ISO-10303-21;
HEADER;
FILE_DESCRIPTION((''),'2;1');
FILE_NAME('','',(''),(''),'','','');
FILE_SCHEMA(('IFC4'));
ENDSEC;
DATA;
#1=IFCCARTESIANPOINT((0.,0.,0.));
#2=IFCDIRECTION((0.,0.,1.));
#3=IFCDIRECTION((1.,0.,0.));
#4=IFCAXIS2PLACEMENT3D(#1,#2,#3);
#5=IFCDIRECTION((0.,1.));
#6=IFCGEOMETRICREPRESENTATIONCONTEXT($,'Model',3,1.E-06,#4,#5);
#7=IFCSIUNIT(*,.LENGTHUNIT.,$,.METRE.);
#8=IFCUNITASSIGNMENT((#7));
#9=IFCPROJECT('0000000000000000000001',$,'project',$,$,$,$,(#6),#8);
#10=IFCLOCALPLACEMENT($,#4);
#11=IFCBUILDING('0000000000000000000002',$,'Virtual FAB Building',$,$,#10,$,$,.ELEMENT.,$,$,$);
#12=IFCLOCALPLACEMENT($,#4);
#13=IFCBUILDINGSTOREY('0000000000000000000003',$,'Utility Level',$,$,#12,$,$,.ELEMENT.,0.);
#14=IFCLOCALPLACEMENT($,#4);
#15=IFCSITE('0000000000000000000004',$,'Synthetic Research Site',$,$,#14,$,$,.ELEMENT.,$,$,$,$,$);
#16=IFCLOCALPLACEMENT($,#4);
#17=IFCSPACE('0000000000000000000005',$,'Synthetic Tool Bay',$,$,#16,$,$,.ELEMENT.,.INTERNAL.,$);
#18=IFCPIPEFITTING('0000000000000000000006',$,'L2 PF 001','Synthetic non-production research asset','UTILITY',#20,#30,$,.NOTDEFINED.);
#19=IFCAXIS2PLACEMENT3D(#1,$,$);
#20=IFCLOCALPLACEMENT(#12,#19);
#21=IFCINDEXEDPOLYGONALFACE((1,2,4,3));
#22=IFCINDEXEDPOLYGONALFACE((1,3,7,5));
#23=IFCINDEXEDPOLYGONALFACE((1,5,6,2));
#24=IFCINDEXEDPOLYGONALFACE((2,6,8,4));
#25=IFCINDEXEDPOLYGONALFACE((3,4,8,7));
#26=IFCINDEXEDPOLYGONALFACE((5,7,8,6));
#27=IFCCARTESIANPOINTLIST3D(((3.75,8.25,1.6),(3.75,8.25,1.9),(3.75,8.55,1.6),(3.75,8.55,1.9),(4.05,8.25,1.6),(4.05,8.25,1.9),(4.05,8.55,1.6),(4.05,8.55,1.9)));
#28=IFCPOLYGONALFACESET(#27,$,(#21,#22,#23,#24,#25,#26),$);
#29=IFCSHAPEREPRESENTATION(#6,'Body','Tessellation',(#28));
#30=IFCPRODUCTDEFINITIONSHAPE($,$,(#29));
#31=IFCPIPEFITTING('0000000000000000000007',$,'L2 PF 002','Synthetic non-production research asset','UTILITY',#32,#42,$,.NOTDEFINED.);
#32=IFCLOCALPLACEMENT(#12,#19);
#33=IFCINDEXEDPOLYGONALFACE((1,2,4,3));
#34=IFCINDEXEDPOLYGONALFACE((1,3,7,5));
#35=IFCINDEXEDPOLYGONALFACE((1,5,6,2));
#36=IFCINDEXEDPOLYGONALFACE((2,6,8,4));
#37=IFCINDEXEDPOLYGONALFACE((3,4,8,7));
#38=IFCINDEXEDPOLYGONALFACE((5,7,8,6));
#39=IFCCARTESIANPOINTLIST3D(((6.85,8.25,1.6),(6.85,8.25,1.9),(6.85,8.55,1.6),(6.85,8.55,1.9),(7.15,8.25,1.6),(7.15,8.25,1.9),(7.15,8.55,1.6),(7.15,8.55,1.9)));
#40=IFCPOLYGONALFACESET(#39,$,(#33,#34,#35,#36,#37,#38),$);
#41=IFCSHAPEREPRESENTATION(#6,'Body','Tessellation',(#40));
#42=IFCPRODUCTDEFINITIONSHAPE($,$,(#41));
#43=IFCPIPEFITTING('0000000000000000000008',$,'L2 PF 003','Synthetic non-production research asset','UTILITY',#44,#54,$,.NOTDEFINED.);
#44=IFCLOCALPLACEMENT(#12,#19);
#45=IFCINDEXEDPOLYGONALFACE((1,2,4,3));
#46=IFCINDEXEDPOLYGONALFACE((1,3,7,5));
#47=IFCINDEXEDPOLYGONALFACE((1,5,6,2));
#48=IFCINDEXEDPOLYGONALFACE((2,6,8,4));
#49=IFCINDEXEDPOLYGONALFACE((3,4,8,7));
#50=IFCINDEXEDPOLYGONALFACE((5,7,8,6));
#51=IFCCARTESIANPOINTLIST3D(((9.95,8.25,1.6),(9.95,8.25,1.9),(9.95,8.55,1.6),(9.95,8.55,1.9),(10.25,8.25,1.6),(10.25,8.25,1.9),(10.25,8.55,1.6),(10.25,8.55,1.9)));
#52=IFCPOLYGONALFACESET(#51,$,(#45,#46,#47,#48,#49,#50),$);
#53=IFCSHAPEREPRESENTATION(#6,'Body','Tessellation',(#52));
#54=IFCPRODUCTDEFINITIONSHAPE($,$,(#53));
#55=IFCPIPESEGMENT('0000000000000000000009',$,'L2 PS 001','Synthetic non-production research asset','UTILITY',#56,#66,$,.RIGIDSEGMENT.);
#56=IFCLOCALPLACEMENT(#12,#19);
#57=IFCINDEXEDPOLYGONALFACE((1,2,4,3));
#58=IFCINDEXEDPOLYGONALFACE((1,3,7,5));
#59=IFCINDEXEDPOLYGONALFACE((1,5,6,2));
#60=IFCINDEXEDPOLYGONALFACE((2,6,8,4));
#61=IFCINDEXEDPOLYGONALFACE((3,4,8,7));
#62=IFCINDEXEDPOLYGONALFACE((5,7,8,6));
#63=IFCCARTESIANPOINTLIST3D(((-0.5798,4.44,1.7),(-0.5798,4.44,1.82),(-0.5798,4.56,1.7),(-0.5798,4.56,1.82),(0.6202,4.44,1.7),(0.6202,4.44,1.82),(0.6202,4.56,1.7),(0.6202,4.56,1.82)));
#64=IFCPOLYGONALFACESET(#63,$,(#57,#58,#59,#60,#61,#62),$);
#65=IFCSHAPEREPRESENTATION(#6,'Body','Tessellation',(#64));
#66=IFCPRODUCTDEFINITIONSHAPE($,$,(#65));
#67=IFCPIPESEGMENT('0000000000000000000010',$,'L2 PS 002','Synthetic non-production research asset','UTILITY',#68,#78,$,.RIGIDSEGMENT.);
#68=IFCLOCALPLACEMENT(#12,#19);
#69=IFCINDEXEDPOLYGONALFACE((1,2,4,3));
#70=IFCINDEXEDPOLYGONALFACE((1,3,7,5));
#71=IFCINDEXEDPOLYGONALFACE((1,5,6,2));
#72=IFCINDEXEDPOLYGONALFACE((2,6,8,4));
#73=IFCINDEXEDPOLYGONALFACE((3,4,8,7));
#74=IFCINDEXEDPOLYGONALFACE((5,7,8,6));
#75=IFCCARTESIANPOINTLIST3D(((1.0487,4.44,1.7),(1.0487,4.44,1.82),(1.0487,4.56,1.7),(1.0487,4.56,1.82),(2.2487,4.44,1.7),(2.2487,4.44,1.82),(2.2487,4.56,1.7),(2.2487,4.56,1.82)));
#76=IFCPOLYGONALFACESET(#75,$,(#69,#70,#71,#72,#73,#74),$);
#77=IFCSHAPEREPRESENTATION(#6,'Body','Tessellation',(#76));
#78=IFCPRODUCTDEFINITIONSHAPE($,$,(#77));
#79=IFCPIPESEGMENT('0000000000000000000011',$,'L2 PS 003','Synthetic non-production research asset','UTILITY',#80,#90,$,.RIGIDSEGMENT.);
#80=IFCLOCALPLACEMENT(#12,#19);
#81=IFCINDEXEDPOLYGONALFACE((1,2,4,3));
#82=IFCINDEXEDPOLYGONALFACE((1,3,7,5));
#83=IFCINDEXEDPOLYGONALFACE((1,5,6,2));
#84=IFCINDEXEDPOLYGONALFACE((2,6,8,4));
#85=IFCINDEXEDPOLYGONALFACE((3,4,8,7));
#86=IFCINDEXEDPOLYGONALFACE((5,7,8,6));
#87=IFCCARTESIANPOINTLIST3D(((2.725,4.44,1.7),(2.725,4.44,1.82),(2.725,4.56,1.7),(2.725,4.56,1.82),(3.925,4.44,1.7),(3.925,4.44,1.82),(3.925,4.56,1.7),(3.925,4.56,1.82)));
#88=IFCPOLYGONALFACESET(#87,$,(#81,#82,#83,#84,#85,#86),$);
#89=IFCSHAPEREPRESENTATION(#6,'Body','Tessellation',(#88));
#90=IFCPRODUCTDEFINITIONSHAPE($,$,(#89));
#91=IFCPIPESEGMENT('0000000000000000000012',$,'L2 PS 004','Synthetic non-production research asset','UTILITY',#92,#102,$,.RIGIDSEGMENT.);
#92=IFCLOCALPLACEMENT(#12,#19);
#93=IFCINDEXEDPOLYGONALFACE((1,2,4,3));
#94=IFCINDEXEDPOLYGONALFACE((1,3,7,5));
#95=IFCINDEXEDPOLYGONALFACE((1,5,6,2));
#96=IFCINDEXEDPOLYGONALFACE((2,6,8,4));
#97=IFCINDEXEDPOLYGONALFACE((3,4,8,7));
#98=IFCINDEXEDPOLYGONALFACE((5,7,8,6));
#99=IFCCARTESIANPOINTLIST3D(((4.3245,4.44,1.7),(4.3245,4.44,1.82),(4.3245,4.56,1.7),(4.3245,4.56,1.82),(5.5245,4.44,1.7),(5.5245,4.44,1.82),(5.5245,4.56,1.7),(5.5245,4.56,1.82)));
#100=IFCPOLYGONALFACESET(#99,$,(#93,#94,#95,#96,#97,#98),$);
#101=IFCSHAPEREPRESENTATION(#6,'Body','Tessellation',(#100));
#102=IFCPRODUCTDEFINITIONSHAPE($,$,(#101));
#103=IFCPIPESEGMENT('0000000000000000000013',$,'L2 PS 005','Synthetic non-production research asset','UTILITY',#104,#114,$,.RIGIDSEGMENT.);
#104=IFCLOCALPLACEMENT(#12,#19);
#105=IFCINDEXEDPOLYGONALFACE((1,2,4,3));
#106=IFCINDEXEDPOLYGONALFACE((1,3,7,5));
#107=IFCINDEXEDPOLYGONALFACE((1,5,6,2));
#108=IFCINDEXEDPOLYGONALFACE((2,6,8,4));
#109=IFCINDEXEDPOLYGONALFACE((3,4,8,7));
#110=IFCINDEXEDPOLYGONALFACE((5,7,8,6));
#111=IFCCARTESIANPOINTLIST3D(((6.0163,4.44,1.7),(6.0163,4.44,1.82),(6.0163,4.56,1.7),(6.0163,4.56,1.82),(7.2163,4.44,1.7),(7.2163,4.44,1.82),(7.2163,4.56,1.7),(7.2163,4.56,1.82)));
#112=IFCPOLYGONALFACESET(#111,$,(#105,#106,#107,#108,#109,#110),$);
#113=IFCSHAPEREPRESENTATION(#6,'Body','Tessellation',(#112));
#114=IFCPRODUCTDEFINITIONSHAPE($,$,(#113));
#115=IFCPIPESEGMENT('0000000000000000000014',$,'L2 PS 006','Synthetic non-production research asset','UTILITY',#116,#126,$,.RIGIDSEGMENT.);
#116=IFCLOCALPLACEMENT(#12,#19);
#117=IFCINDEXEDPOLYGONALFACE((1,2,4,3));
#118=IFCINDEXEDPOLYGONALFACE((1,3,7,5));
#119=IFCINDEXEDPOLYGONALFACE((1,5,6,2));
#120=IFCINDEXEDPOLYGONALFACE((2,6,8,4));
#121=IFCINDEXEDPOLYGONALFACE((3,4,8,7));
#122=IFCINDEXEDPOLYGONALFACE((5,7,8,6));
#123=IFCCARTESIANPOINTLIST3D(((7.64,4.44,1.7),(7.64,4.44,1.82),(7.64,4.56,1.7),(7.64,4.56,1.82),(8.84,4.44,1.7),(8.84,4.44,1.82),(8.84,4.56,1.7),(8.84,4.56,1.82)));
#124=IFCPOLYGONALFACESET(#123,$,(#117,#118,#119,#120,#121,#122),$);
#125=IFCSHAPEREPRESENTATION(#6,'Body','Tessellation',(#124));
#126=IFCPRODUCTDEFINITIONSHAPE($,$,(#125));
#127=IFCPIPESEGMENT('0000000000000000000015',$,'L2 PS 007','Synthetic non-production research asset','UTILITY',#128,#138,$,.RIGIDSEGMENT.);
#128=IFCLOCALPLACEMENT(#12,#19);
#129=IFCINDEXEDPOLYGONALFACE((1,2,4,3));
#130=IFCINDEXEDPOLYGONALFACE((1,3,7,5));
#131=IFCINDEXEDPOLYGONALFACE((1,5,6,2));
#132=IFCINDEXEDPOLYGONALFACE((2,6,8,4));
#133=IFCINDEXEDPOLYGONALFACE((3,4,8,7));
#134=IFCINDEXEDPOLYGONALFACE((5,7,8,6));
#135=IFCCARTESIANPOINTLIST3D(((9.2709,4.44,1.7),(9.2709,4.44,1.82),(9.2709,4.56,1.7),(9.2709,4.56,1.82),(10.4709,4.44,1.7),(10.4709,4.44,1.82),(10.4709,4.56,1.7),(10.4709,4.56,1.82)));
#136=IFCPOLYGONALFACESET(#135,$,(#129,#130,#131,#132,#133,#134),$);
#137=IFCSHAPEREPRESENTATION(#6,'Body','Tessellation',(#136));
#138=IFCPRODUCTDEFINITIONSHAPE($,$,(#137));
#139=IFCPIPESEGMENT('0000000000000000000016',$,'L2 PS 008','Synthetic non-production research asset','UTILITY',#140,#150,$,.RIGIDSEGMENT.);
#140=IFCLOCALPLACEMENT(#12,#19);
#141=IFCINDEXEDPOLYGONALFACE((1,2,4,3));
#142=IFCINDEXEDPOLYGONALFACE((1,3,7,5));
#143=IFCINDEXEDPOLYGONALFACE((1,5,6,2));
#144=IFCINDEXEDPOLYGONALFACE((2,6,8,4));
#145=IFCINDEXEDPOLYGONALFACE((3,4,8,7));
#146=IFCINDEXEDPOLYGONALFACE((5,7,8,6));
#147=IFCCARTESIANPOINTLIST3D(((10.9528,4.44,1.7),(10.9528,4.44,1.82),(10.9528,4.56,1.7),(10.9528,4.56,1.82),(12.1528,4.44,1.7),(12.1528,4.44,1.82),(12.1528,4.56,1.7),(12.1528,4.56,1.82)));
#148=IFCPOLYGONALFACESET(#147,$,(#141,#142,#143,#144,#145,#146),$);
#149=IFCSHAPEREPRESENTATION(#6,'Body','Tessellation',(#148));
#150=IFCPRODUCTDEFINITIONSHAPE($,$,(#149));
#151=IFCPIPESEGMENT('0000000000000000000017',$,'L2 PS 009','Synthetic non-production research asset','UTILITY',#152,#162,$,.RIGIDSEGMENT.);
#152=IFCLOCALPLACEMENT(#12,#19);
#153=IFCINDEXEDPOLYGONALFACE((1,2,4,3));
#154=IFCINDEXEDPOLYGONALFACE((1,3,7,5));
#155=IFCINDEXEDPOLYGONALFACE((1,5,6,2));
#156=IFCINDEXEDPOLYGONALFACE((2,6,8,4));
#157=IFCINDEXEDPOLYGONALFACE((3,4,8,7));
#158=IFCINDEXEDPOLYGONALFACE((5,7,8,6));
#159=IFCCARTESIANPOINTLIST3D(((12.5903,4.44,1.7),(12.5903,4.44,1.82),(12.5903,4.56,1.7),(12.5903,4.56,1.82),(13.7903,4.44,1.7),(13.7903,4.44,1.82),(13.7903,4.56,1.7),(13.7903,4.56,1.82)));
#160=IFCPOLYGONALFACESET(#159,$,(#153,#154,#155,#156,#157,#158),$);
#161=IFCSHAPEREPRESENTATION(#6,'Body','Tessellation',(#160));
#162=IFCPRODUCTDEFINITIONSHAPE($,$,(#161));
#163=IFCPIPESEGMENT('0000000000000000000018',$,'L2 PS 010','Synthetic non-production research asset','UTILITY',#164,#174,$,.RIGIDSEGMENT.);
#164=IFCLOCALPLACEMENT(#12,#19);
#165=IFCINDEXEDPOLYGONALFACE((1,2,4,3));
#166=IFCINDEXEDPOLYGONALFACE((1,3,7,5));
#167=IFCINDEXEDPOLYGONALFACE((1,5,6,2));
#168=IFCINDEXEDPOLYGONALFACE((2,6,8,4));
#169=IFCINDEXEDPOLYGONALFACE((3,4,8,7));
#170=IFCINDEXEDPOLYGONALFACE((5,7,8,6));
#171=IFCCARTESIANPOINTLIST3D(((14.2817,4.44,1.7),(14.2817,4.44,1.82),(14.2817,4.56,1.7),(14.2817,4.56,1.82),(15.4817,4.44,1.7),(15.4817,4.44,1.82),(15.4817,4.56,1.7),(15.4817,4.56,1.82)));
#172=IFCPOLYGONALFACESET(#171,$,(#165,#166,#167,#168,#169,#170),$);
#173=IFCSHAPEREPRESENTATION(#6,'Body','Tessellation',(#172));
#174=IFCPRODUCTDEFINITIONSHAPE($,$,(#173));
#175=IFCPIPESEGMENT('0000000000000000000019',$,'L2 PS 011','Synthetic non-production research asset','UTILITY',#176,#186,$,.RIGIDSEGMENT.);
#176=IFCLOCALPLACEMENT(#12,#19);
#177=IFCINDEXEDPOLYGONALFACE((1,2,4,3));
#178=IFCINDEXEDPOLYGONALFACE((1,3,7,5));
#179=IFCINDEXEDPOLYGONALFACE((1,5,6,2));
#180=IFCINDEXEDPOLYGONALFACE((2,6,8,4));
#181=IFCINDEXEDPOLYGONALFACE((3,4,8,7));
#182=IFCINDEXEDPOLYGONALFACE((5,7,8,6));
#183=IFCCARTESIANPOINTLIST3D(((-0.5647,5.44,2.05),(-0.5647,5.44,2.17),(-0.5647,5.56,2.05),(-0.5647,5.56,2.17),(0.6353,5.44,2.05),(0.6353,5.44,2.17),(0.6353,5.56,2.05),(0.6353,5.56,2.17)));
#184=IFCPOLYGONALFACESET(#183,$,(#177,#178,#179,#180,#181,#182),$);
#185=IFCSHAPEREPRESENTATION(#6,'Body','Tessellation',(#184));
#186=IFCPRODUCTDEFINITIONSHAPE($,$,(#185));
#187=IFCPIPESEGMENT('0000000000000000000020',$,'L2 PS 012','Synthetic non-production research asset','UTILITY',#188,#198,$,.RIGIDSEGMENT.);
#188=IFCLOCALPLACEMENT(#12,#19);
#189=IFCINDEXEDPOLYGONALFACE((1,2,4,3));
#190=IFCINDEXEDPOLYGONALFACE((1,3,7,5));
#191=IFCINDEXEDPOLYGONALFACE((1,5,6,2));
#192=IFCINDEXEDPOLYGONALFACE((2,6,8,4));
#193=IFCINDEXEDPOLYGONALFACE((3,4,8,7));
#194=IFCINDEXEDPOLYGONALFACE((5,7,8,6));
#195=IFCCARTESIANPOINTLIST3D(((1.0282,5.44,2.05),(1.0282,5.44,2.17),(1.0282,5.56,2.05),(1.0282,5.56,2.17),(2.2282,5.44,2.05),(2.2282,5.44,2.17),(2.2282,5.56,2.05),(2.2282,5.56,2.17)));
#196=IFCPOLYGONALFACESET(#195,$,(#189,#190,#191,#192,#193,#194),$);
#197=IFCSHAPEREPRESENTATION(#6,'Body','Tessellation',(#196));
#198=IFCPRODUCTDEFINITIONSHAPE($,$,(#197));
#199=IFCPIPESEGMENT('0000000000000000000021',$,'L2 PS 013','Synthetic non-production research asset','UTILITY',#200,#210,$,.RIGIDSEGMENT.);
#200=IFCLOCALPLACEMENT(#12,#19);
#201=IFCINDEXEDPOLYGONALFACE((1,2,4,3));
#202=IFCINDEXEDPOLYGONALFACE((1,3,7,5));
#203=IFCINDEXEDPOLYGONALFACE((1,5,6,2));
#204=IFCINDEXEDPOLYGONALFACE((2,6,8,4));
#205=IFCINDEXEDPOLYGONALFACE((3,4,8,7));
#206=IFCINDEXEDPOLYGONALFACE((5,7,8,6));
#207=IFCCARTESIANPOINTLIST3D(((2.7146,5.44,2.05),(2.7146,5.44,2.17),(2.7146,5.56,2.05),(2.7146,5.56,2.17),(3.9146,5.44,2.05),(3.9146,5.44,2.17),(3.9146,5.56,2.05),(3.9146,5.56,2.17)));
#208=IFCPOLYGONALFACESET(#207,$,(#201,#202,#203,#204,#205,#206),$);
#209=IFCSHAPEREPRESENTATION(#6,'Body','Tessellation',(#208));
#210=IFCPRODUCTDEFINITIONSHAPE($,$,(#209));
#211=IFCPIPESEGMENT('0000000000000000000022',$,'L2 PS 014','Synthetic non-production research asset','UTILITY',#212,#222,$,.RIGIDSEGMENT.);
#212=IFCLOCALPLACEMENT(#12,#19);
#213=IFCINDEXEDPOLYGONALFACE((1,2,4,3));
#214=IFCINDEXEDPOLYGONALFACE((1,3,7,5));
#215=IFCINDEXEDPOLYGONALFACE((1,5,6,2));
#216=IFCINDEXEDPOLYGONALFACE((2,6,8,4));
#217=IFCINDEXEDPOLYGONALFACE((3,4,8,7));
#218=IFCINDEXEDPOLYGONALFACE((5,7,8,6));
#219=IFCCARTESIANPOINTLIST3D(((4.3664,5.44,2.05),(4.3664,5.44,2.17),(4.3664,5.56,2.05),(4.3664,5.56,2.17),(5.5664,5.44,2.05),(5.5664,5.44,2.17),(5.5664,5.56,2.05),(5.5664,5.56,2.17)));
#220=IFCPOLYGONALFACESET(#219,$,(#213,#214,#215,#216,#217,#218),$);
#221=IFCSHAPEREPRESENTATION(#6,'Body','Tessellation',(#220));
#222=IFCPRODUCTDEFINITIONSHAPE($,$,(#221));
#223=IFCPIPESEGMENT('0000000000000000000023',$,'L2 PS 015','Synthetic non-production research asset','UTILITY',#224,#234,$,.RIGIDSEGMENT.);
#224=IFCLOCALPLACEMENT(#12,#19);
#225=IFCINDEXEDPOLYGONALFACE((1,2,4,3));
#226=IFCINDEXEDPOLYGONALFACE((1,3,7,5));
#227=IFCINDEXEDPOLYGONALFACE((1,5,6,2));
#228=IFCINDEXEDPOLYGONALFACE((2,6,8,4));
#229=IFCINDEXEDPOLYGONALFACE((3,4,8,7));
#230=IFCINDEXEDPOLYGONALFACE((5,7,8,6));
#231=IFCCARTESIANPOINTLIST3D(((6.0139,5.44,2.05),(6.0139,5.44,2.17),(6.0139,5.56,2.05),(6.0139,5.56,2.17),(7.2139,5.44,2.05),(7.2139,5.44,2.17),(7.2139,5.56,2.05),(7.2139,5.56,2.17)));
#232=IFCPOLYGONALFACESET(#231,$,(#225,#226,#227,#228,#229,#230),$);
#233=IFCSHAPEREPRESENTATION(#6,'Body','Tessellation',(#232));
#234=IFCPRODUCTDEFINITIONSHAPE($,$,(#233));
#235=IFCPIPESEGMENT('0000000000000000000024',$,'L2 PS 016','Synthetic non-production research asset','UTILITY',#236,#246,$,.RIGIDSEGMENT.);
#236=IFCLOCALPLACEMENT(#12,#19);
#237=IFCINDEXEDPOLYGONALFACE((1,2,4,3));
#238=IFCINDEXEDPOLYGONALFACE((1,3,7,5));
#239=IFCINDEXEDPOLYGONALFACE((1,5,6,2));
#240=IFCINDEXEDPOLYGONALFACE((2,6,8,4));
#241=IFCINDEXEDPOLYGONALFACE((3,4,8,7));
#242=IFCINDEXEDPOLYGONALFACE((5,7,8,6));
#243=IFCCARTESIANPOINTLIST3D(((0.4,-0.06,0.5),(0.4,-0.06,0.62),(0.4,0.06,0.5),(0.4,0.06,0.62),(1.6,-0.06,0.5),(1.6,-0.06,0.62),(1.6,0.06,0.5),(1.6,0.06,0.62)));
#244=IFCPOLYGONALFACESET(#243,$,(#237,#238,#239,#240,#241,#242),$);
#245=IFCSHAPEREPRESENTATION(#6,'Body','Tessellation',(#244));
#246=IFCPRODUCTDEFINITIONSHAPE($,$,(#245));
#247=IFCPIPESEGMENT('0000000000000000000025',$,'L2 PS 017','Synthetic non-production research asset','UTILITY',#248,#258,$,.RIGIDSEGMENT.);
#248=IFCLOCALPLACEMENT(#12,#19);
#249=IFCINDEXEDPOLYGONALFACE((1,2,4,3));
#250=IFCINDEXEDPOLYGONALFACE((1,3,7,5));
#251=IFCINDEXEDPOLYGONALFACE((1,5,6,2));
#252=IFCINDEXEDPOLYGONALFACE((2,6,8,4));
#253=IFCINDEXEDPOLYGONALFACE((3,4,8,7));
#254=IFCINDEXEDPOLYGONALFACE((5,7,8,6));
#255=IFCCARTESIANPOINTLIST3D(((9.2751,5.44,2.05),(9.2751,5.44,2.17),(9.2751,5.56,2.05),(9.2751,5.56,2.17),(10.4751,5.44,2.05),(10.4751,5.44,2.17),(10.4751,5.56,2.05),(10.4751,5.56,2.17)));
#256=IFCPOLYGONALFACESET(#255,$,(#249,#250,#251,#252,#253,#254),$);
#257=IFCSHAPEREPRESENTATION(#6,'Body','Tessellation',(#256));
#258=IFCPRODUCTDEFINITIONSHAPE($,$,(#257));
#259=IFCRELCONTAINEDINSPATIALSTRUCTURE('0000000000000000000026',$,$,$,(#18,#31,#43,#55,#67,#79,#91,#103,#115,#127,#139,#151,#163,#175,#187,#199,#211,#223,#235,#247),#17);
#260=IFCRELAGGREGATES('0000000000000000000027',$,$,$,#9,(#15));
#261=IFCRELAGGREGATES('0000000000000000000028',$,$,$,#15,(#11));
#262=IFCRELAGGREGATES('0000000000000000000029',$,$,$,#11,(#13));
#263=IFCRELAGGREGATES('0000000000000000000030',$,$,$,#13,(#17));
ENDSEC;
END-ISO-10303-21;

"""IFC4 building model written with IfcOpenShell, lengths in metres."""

from ifc_helpers import new_model, si_unit, direction, frame, origin_with_axes, origin_2d_with_axis, place, context, project, spatial, rectangle, extrude, element, save


model = new_model("IFC4")

# Units and contexts
model_context = context("Model", 3, precision=1e-06, world=origin_with_axes(), true_north=direction((0.0, 1.0)))
ifc_project = project(units=[si_unit("LENGTHUNIT", "METRE")], contexts=[model_context])

# Site, building, storey, space
site_placement = place(None, origin_with_axes())
site = spatial("IfcSite", under=ifc_project, at=site_placement, Name="Synthetic Research Site", CompositionType="ELEMENT")
building_placement = place(None, origin_with_axes())
building = spatial("IfcBuilding", under=site, at=building_placement, Name="Virtual FAB Building", CompositionType="ELEMENT")
storey_placement = place(None, origin_with_axes())
storey = spatial("IfcBuildingStorey", under=building, at=storey_placement, Name="Utility Level", CompositionType="ELEMENT", Elevation=0.0)
space_placement = place(None, origin_with_axes())
space = spatial("IfcSpace", under=storey, at=space_placement, Name="Synthetic Tool Bay", CompositionType="ELEMENT", PredefinedType="INTERNAL")

# Pipe fittings
for number, where, z_axis, x_axis, name in (
    (1, (3.9, 8.4, 1.6), (0.0, 0.0, 1.0), (1.0, 0.0, 0.0), "L2 PF 001"),
    (2, (7.0, 8.4, 1.6), (0.0, 0.0, 1.0), (1.0, 0.0, 0.0), "L2 PF 002"),
    (3, (10.1, 8.4, 1.6), (0.0, 0.0, 1.0), (1.0, 0.0, 0.0), "L2 PF 003"),
):
    element("IfcPipeFitting", number, at=place(None, frame(where, z_axis=z_axis, x_axis=x_axis)), inside=space, Name=name, Description="Synthetic non-production research asset", ObjectType="UTILITY", PredefinedType="NOTDEFINED", context=model_context, shape_type="SweptSolid", body=[
        extrude(rectangle(XDim=0.3, YDim=0.3, at=origin_2d_with_axis()), origin_with_axes(), (0.0, 0.0, 1.0), 0.3),
    ])

# Pipe segments
for number, where, z_axis, x_axis, name in (
    (4, (0.0202, 4.5, 1.7), (0.0, 0.0, 1.0), (1.0, 0.0, 0.0), "L2 PS 001"),
    (5, (1.6487, 4.5, 1.7), (0.0, 0.0, 1.0), (1.0, 0.0, 0.0), "L2 PS 002"),
    (6, (3.325, 4.5, 1.7), (0.0, 0.0, 1.0), (1.0, 0.0, 0.0), "L2 PS 003"),
    (7, (4.9245, 4.5, 1.7), (0.0, 0.0, 1.0), (1.0, 0.0, 0.0), "L2 PS 004"),
    (8, (6.6163, 4.5, 1.7), (0.0, 0.0, 1.0), (1.0, 0.0, 0.0), "L2 PS 005"),
    (9, (8.24, 4.5, 1.7), (0.0, 0.0, 1.0), (1.0, 0.0, 0.0), "L2 PS 006"),
    (10, (9.8709, 4.5, 1.7), (0.0, 0.0, 1.0), (1.0, 0.0, 0.0), "L2 PS 007"),
    (11, (11.5528, 4.5, 1.7), (0.0, 0.0, 1.0), (1.0, 0.0, 0.0), "L2 PS 008"),
    (12, (13.1903, 4.5, 1.7), (0.0, 0.0, 1.0), (1.0, 0.0, 0.0), "L2 PS 009"),
    (13, (14.8817, 4.5, 1.7), (0.0, 0.0, 1.0), (1.0, 0.0, 0.0), "L2 PS 010"),
    (14, (0.0353, 5.5, 2.05), (0.0, 0.0, 1.0), (1.0, 0.0, 0.0), "L2 PS 011"),
    (15, (1.6282, 5.5, 2.05), (0.0, 0.0, 1.0), (1.0, 0.0, 0.0), "L2 PS 012"),
    (16, (3.3146, 5.5, 2.05), (0.0, 0.0, 1.0), (1.0, 0.0, 0.0), "L2 PS 013"),
    (17, (4.9664, 5.5, 2.05), (0.0, 0.0, 1.0), (1.0, 0.0, 0.0), "L2 PS 014"),
    (18, (6.6139, 5.5, 2.05), (0.0, 0.0, 1.0), (1.0, 0.0, 0.0), "L2 PS 015"),
    (19, (1.0, 0.0, 0.5), (0.0, 0.0, 1.0), (1.0, 0.0, 0.0), "L2 PS 016"),
    (20, (9.8751, 5.5, 2.05), (0.0, 0.0, 1.0), (1.0, 0.0, 0.0), "L2 PS 017"),
):
    element("IfcPipeSegment", number, at=place(None, frame(where, z_axis=z_axis, x_axis=x_axis)), inside=space, Name=name, Description="Synthetic non-production research asset", ObjectType="UTILITY", PredefinedType="RIGIDSEGMENT", context=model_context, shape_type="SweptSolid", body=[
        extrude(rectangle(XDim=1.2, YDim=0.12, at=origin_2d_with_axis()), origin_with_axes(), (0.0, 0.0, 1.0), 0.12),
    ])

save(model, "model.ifc")
